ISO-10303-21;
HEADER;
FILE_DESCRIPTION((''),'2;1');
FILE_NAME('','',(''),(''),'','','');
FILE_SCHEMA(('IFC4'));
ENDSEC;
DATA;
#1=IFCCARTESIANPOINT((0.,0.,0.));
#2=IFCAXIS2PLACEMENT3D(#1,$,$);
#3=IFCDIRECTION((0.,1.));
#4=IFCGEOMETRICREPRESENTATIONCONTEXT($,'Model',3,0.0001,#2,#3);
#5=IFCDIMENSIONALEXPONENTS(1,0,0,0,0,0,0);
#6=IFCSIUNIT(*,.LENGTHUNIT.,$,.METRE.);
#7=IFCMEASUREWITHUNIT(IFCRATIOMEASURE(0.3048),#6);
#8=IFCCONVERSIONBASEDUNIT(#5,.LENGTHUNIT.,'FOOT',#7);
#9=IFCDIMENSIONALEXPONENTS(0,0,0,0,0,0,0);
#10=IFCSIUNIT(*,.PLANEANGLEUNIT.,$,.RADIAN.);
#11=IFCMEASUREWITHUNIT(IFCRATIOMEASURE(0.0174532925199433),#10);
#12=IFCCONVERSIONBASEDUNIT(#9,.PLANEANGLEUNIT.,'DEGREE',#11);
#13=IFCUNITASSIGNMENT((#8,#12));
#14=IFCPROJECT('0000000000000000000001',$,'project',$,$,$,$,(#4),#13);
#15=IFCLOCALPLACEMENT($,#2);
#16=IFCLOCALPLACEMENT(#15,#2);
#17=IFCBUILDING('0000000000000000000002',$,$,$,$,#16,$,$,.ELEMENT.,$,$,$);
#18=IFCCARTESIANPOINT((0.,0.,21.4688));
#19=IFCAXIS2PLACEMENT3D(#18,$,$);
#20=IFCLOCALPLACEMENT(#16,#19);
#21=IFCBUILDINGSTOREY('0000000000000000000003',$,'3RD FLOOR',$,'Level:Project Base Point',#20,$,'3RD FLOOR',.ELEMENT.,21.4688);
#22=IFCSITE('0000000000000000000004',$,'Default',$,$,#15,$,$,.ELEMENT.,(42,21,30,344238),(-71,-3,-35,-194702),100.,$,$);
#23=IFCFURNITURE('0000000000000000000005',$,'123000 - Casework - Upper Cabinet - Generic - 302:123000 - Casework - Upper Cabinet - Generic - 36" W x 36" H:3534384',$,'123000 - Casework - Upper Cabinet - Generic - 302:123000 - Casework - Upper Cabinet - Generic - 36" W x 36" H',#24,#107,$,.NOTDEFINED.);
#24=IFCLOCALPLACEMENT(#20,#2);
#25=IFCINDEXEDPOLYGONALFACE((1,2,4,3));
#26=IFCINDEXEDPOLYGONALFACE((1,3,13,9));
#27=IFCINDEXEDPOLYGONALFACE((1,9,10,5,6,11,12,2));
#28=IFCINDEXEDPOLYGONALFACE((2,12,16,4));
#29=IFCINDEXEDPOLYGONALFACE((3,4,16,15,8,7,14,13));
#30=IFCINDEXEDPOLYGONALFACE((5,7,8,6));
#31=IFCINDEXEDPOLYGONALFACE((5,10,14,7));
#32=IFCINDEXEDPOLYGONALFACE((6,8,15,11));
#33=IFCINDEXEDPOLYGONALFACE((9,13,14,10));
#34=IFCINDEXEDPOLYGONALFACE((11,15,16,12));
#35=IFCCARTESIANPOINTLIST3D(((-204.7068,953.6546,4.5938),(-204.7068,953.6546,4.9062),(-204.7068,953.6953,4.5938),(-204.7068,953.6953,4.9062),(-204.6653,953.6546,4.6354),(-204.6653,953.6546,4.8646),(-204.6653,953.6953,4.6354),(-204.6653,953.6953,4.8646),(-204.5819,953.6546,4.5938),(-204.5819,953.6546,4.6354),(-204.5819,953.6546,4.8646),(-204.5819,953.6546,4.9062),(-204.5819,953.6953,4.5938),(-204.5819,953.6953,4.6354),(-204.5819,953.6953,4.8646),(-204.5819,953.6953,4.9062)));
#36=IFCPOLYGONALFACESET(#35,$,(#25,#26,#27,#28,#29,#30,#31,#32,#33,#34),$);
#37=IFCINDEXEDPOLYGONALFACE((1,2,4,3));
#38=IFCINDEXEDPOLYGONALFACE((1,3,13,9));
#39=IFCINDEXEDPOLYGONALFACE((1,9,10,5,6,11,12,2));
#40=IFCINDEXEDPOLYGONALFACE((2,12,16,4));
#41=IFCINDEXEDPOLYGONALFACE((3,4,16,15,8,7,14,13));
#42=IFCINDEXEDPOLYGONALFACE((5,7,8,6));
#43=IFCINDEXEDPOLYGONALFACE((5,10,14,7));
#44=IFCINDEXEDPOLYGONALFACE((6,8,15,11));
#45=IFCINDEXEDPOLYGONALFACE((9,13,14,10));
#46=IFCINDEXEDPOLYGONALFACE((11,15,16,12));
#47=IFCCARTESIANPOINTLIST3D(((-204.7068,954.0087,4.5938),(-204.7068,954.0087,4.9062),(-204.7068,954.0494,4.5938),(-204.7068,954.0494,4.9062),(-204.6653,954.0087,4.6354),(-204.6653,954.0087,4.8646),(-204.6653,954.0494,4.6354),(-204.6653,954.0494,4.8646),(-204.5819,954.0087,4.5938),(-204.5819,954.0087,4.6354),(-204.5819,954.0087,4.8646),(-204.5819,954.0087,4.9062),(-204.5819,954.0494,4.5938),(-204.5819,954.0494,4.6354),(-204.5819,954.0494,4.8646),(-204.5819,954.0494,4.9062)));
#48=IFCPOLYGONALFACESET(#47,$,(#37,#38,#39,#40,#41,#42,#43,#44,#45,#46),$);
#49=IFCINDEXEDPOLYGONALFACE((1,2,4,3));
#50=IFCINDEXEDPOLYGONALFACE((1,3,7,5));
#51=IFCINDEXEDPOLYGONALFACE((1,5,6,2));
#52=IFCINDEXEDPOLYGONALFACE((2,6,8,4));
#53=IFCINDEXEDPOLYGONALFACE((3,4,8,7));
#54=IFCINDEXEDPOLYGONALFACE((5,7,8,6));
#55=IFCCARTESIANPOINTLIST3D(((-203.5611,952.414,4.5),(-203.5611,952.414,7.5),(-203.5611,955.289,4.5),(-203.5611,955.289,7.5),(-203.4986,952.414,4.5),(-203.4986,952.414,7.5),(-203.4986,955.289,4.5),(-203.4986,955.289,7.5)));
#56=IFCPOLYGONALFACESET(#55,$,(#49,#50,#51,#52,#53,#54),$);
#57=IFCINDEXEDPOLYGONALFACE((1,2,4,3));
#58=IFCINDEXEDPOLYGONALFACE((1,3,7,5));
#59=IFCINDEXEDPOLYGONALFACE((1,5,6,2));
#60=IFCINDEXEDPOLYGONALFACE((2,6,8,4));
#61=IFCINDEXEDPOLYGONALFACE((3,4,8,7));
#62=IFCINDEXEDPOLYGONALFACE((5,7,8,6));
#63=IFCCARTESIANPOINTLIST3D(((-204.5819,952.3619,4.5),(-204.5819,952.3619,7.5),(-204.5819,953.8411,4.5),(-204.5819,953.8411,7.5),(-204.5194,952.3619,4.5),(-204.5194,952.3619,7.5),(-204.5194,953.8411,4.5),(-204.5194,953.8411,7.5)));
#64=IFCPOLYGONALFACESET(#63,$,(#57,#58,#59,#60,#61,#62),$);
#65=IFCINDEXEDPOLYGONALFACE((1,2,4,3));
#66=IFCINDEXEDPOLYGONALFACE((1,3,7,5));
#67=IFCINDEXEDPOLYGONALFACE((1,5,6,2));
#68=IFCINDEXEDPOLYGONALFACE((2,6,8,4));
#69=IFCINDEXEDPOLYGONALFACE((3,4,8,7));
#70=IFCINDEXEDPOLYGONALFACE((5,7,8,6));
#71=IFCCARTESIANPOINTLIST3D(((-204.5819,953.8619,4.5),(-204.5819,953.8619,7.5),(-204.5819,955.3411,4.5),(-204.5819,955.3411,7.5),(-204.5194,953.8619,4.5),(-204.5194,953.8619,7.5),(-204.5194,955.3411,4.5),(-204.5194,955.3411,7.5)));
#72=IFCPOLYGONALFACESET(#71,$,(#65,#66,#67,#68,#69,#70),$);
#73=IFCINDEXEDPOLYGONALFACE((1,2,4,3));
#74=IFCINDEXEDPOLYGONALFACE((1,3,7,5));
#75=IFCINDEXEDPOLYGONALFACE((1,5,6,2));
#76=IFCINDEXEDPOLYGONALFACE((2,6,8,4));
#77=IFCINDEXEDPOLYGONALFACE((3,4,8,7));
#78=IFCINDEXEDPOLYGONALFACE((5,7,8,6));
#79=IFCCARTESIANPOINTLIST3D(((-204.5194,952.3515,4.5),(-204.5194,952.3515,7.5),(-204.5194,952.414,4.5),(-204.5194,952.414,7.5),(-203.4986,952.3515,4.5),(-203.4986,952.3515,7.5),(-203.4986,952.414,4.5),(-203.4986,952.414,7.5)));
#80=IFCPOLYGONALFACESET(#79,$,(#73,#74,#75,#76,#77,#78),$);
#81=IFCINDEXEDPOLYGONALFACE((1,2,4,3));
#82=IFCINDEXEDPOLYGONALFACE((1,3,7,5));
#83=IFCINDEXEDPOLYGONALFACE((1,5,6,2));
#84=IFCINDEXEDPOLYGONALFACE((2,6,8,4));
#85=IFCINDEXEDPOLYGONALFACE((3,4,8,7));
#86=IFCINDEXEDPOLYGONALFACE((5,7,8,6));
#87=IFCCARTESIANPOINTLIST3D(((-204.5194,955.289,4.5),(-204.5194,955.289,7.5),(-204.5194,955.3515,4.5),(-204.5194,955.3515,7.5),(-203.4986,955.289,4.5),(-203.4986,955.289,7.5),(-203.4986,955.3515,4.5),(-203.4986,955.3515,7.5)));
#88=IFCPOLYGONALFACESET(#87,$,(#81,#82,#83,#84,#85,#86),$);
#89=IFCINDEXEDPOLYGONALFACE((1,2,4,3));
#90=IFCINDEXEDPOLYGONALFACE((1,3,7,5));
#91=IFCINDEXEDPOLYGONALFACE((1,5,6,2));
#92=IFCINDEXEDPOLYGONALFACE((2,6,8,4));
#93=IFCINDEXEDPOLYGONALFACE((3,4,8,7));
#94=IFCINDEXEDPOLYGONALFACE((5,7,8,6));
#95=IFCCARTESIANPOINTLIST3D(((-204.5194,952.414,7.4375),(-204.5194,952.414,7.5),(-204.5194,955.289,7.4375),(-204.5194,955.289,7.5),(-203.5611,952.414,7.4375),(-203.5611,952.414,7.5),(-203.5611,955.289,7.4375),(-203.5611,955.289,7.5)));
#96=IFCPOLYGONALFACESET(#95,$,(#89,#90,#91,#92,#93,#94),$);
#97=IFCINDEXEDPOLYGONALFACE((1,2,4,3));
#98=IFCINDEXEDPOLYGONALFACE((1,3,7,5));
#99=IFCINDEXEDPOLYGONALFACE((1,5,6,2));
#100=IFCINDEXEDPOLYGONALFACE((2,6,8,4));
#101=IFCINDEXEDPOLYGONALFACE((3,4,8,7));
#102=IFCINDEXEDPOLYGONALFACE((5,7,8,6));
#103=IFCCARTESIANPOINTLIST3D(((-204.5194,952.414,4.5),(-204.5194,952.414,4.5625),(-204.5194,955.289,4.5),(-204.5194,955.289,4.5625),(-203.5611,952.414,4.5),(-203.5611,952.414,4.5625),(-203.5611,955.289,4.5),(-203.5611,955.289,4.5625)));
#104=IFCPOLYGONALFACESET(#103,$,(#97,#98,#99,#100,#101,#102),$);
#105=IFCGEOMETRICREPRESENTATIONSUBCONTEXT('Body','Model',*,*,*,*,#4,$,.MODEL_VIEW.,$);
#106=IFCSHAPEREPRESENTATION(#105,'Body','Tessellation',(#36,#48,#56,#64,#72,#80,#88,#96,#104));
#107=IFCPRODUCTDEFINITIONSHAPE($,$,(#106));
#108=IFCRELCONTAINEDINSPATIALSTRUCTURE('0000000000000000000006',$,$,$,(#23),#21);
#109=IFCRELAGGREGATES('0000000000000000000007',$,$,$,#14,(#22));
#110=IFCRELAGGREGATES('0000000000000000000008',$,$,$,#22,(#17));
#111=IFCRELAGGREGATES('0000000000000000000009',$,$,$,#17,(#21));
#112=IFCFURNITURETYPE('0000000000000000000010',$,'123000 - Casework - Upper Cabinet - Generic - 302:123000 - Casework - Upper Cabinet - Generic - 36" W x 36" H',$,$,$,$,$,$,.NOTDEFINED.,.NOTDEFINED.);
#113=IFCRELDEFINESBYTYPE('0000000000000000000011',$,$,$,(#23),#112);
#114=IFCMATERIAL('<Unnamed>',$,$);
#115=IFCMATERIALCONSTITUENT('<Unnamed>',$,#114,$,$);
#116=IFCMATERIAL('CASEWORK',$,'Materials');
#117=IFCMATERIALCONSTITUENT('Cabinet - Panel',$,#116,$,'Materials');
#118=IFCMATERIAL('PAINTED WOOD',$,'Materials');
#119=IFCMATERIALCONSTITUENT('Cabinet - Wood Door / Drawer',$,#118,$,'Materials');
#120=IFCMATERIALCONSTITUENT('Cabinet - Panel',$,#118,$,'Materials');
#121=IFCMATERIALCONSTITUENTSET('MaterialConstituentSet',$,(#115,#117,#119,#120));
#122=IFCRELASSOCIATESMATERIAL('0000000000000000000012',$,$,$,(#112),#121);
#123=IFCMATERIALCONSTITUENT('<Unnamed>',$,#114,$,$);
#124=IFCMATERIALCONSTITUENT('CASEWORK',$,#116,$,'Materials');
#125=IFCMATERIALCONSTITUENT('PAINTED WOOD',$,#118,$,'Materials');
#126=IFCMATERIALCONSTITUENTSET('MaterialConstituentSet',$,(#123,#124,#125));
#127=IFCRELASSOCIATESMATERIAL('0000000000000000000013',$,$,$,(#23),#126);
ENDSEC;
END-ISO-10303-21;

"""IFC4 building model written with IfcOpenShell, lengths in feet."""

from ifc_helpers import new_model, entity, si_unit, converted_unit, direction, frame, frame_2d, origin, origin_2d_with_axis, place, context, subcontext, project, spatial, polyline, rectangle, outline, extrude, source, transform, mapped, material, constituent, constituent_set, type_object, type_shapes, element, save


model = new_model("IFC4")

# Units and contexts
model_context = context("Model", 3, precision=0.0001, world=origin(), true_north=direction((0.0, 1.0)))
body_context = subcontext(model_context, "Body", "Model", "MODEL_VIEW")
ifc_project = project(units=[converted_unit("LENGTHUNIT", "FOOT", entity("IfcRatioMeasure", 0.3048), si_unit("LENGTHUNIT", "METRE"), dimensions=[1, 0, 0, 0, 0, 0, 0]), converted_unit("PLANEANGLEUNIT", "DEGREE", entity("IfcRatioMeasure", 0.0174532925199433), si_unit("PLANEANGLEUNIT", "RADIAN"), dimensions=[0, 0, 0, 0, 0, 0, 0])], contexts=[model_context])

# Site, building, storey
site_placement = place(None, origin())
site = spatial("IfcSite", under=ifc_project, at=site_placement, Name="Default", CompositionType="ELEMENT", RefLatitude=(42, 21, 30, 344238), RefLongitude=(-71, -3, -35, -194702), RefElevation=100.0)
building_placement = place(site_placement, origin())
building = spatial("IfcBuilding", under=site, at=building_placement, CompositionType="ELEMENT")
storey_placement = place(building_placement, frame((0.0, 0.0, 21.4688)))
storey = spatial("IfcBuildingStorey", under=building, at=storey_placement, Name="3RD FLOOR", ObjectType="Level:Project Base Point", LongName="3RD FLOOR", CompositionType="ELEMENT", Elevation=21.4688)

# Furniture
ifc_material_1 = material(Name="CASEWORK", Category="Materials")
ifc_material_2 = material(Name="<Unnamed>")
ifc_material_3 = material(Name="PAINTED WOOD", Category="Materials")
ifc_constituent_1 = constituent(ifc_material_2, Name="<Unnamed>")
ifc_constituent_2 = constituent(ifc_material_1, Name="CASEWORK", Category="Materials")
ifc_constituent_3 = constituent(ifc_material_3, Name="PAINTED WOOD", Category="Materials")
ifc_constituent_set_1 = constituent_set(constituents=[ifc_constituent_1, ifc_constituent_2, ifc_constituent_3], Name="MaterialConstituentSet")
ifc_constituent_4 = constituent(ifc_material_2, Name="<Unnamed>")
ifc_constituent_5 = constituent(ifc_material_1, Name="Cabinet - Panel", Category="Materials")
ifc_constituent_6 = constituent(ifc_material_3, Name="Cabinet - Wood Door / Drawer", Category="Materials")
ifc_constituent_7 = constituent(ifc_material_3, Name="Cabinet - Panel", Category="Materials")
ifc_constituent_set_2 = constituent_set(constituents=[ifc_constituent_4, ifc_constituent_5, ifc_constituent_6, ifc_constituent_7], Name="MaterialConstituentSet")
furniture_type_1 = type_object("IfcFurnitureType", Name="123000 - Casework - Upper Cabinet - Generic - 302:123000 - Casework - Upper Cabinet - Generic - 36\" W x 36\" H", AssemblyPlace="NOTDEFINED", PredefinedType="NOTDEFINED", material=ifc_constituent_set_2)
shared_shape_1 = source(origin(), body_context, "Body", "SweptSolid", [
    extrude(outline(polyline([(-0.0521, -0.1146), (-0.0521, -0.1562), (0.0729, -0.1562), (0.0729, 0.1562), (-0.0521, 0.1562), (-0.0521, 0.1146), (0.0313, 0.1146), (0.0313, -0.1146), (-0.0521, -0.1146)])), frame((1.303, 1.1354, 0.25), z_axis=(-1.0, 0.0, 0.0), x_axis=(0.0, 1.0, 0.0)), (0.0, 0.0, -1.0), 0.0407),
    extrude(outline(polyline([(-0.0521, -0.1146), (-0.0521, -0.1562), (0.0729, -0.1562), (0.0729, 0.1562), (-0.0521, 0.1562), (-0.0521, 0.1146), (0.0313, 0.1146), (0.0313, -0.1146), (-0.0521, -0.1146)])), frame((1.6572, 1.1354, 0.25), z_axis=(-1.0, 0.0, 0.0), x_axis=(0.0, 1.0, 0.0)), (0.0, 0.0, -1.0), 0.0407),
    extrude(rectangle(XDim=2.875, YDim=0.0625, at=frame_2d((0.0, 0.0), x_axis=(1.0, 0.0))), frame((1.5, 0.0313, 0.0), z_axis=(0.0, 0.0, 1.0), x_axis=(-1.0, 0.0, 0.0)), (0.0, 0.0, 1.0), 3.0),
    extrude(rectangle(XDim=1.4792, YDim=0.0625, at=origin_2d_with_axis()), frame((0.75, 1.0521, 0.0)), (0.0, 0.0, 1.0), 3.0),
    extrude(rectangle(XDim=1.4792, YDim=0.0625, at=origin_2d_with_axis()), frame((2.25, 1.0521, 0.0)), (0.0, 0.0, 1.0), 3.0),
    extrude(rectangle(XDim=1.0208, YDim=0.0625, at=origin_2d_with_axis()), frame((0.0312, 0.5104, 0.0), z_axis=(0.0, 0.0, 1.0), x_axis=(0.0, 1.0, 0.0)), (0.0, 0.0, 1.0), 3.0),
    extrude(rectangle(XDim=1.0208, YDim=0.0625, at=frame_2d((0.0, 0.0), x_axis=(1.0, 0.0))), frame((2.9688, 0.5104, 0.0), z_axis=(0.0, 0.0, 1.0), x_axis=(0.0, 1.0, 0.0)), (0.0, 0.0, 1.0), 3.0),
    extrude(rectangle(XDim=0.9583, YDim=2.875, at=frame_2d((0.0, 0.0), x_axis=(1.0, 0.0))), frame((1.5, 0.5417, 2.9375), z_axis=(0.0, 0.0, 1.0), x_axis=(0.0, 1.0, 0.0)), (0.0, 0.0, 1.0), 0.0625),
    extrude(rectangle(XDim=0.9583, YDim=2.875, at=frame_2d((0.0, 0.0), x_axis=(1.0, 0.0))), frame((1.5, 0.5417, 0.0), z_axis=(0.0, 0.0, 1.0), x_axis=(0.0, 1.0, 0.0)), (0.0, 0.0, 1.0), 0.0625),
])
type_shapes(furniture_type_1, [shared_shape_1])
furniture_1_placement = place(storey_placement, frame((-203.4986, 952.3515, 4.5), z_axis=(0.0, 0.0, 1.0), x_axis=(0.0, 1.0, 0.0)))
element("IfcFurniture", 1, at=furniture_1_placement, inside=storey, type_object=furniture_type_1, material=ifc_constituent_set_1, Name="123000 - Casework - Upper Cabinet - Generic - 302:123000 - Casework - Upper Cabinet - Generic - 36\" W x 36\" H:3534384", ObjectType="123000 - Casework - Upper Cabinet - Generic - 302:123000 - Casework - Upper Cabinet - Generic - 36\" W x 36\" H", PredefinedType="NOTDEFINED", context=body_context, shape_type="MappedRepresentation", body=[
    mapped(shared_shape_1, transform((0.0, 0.0, 0.0), scale=1.0)),
])

save(model, "model.ifc")
